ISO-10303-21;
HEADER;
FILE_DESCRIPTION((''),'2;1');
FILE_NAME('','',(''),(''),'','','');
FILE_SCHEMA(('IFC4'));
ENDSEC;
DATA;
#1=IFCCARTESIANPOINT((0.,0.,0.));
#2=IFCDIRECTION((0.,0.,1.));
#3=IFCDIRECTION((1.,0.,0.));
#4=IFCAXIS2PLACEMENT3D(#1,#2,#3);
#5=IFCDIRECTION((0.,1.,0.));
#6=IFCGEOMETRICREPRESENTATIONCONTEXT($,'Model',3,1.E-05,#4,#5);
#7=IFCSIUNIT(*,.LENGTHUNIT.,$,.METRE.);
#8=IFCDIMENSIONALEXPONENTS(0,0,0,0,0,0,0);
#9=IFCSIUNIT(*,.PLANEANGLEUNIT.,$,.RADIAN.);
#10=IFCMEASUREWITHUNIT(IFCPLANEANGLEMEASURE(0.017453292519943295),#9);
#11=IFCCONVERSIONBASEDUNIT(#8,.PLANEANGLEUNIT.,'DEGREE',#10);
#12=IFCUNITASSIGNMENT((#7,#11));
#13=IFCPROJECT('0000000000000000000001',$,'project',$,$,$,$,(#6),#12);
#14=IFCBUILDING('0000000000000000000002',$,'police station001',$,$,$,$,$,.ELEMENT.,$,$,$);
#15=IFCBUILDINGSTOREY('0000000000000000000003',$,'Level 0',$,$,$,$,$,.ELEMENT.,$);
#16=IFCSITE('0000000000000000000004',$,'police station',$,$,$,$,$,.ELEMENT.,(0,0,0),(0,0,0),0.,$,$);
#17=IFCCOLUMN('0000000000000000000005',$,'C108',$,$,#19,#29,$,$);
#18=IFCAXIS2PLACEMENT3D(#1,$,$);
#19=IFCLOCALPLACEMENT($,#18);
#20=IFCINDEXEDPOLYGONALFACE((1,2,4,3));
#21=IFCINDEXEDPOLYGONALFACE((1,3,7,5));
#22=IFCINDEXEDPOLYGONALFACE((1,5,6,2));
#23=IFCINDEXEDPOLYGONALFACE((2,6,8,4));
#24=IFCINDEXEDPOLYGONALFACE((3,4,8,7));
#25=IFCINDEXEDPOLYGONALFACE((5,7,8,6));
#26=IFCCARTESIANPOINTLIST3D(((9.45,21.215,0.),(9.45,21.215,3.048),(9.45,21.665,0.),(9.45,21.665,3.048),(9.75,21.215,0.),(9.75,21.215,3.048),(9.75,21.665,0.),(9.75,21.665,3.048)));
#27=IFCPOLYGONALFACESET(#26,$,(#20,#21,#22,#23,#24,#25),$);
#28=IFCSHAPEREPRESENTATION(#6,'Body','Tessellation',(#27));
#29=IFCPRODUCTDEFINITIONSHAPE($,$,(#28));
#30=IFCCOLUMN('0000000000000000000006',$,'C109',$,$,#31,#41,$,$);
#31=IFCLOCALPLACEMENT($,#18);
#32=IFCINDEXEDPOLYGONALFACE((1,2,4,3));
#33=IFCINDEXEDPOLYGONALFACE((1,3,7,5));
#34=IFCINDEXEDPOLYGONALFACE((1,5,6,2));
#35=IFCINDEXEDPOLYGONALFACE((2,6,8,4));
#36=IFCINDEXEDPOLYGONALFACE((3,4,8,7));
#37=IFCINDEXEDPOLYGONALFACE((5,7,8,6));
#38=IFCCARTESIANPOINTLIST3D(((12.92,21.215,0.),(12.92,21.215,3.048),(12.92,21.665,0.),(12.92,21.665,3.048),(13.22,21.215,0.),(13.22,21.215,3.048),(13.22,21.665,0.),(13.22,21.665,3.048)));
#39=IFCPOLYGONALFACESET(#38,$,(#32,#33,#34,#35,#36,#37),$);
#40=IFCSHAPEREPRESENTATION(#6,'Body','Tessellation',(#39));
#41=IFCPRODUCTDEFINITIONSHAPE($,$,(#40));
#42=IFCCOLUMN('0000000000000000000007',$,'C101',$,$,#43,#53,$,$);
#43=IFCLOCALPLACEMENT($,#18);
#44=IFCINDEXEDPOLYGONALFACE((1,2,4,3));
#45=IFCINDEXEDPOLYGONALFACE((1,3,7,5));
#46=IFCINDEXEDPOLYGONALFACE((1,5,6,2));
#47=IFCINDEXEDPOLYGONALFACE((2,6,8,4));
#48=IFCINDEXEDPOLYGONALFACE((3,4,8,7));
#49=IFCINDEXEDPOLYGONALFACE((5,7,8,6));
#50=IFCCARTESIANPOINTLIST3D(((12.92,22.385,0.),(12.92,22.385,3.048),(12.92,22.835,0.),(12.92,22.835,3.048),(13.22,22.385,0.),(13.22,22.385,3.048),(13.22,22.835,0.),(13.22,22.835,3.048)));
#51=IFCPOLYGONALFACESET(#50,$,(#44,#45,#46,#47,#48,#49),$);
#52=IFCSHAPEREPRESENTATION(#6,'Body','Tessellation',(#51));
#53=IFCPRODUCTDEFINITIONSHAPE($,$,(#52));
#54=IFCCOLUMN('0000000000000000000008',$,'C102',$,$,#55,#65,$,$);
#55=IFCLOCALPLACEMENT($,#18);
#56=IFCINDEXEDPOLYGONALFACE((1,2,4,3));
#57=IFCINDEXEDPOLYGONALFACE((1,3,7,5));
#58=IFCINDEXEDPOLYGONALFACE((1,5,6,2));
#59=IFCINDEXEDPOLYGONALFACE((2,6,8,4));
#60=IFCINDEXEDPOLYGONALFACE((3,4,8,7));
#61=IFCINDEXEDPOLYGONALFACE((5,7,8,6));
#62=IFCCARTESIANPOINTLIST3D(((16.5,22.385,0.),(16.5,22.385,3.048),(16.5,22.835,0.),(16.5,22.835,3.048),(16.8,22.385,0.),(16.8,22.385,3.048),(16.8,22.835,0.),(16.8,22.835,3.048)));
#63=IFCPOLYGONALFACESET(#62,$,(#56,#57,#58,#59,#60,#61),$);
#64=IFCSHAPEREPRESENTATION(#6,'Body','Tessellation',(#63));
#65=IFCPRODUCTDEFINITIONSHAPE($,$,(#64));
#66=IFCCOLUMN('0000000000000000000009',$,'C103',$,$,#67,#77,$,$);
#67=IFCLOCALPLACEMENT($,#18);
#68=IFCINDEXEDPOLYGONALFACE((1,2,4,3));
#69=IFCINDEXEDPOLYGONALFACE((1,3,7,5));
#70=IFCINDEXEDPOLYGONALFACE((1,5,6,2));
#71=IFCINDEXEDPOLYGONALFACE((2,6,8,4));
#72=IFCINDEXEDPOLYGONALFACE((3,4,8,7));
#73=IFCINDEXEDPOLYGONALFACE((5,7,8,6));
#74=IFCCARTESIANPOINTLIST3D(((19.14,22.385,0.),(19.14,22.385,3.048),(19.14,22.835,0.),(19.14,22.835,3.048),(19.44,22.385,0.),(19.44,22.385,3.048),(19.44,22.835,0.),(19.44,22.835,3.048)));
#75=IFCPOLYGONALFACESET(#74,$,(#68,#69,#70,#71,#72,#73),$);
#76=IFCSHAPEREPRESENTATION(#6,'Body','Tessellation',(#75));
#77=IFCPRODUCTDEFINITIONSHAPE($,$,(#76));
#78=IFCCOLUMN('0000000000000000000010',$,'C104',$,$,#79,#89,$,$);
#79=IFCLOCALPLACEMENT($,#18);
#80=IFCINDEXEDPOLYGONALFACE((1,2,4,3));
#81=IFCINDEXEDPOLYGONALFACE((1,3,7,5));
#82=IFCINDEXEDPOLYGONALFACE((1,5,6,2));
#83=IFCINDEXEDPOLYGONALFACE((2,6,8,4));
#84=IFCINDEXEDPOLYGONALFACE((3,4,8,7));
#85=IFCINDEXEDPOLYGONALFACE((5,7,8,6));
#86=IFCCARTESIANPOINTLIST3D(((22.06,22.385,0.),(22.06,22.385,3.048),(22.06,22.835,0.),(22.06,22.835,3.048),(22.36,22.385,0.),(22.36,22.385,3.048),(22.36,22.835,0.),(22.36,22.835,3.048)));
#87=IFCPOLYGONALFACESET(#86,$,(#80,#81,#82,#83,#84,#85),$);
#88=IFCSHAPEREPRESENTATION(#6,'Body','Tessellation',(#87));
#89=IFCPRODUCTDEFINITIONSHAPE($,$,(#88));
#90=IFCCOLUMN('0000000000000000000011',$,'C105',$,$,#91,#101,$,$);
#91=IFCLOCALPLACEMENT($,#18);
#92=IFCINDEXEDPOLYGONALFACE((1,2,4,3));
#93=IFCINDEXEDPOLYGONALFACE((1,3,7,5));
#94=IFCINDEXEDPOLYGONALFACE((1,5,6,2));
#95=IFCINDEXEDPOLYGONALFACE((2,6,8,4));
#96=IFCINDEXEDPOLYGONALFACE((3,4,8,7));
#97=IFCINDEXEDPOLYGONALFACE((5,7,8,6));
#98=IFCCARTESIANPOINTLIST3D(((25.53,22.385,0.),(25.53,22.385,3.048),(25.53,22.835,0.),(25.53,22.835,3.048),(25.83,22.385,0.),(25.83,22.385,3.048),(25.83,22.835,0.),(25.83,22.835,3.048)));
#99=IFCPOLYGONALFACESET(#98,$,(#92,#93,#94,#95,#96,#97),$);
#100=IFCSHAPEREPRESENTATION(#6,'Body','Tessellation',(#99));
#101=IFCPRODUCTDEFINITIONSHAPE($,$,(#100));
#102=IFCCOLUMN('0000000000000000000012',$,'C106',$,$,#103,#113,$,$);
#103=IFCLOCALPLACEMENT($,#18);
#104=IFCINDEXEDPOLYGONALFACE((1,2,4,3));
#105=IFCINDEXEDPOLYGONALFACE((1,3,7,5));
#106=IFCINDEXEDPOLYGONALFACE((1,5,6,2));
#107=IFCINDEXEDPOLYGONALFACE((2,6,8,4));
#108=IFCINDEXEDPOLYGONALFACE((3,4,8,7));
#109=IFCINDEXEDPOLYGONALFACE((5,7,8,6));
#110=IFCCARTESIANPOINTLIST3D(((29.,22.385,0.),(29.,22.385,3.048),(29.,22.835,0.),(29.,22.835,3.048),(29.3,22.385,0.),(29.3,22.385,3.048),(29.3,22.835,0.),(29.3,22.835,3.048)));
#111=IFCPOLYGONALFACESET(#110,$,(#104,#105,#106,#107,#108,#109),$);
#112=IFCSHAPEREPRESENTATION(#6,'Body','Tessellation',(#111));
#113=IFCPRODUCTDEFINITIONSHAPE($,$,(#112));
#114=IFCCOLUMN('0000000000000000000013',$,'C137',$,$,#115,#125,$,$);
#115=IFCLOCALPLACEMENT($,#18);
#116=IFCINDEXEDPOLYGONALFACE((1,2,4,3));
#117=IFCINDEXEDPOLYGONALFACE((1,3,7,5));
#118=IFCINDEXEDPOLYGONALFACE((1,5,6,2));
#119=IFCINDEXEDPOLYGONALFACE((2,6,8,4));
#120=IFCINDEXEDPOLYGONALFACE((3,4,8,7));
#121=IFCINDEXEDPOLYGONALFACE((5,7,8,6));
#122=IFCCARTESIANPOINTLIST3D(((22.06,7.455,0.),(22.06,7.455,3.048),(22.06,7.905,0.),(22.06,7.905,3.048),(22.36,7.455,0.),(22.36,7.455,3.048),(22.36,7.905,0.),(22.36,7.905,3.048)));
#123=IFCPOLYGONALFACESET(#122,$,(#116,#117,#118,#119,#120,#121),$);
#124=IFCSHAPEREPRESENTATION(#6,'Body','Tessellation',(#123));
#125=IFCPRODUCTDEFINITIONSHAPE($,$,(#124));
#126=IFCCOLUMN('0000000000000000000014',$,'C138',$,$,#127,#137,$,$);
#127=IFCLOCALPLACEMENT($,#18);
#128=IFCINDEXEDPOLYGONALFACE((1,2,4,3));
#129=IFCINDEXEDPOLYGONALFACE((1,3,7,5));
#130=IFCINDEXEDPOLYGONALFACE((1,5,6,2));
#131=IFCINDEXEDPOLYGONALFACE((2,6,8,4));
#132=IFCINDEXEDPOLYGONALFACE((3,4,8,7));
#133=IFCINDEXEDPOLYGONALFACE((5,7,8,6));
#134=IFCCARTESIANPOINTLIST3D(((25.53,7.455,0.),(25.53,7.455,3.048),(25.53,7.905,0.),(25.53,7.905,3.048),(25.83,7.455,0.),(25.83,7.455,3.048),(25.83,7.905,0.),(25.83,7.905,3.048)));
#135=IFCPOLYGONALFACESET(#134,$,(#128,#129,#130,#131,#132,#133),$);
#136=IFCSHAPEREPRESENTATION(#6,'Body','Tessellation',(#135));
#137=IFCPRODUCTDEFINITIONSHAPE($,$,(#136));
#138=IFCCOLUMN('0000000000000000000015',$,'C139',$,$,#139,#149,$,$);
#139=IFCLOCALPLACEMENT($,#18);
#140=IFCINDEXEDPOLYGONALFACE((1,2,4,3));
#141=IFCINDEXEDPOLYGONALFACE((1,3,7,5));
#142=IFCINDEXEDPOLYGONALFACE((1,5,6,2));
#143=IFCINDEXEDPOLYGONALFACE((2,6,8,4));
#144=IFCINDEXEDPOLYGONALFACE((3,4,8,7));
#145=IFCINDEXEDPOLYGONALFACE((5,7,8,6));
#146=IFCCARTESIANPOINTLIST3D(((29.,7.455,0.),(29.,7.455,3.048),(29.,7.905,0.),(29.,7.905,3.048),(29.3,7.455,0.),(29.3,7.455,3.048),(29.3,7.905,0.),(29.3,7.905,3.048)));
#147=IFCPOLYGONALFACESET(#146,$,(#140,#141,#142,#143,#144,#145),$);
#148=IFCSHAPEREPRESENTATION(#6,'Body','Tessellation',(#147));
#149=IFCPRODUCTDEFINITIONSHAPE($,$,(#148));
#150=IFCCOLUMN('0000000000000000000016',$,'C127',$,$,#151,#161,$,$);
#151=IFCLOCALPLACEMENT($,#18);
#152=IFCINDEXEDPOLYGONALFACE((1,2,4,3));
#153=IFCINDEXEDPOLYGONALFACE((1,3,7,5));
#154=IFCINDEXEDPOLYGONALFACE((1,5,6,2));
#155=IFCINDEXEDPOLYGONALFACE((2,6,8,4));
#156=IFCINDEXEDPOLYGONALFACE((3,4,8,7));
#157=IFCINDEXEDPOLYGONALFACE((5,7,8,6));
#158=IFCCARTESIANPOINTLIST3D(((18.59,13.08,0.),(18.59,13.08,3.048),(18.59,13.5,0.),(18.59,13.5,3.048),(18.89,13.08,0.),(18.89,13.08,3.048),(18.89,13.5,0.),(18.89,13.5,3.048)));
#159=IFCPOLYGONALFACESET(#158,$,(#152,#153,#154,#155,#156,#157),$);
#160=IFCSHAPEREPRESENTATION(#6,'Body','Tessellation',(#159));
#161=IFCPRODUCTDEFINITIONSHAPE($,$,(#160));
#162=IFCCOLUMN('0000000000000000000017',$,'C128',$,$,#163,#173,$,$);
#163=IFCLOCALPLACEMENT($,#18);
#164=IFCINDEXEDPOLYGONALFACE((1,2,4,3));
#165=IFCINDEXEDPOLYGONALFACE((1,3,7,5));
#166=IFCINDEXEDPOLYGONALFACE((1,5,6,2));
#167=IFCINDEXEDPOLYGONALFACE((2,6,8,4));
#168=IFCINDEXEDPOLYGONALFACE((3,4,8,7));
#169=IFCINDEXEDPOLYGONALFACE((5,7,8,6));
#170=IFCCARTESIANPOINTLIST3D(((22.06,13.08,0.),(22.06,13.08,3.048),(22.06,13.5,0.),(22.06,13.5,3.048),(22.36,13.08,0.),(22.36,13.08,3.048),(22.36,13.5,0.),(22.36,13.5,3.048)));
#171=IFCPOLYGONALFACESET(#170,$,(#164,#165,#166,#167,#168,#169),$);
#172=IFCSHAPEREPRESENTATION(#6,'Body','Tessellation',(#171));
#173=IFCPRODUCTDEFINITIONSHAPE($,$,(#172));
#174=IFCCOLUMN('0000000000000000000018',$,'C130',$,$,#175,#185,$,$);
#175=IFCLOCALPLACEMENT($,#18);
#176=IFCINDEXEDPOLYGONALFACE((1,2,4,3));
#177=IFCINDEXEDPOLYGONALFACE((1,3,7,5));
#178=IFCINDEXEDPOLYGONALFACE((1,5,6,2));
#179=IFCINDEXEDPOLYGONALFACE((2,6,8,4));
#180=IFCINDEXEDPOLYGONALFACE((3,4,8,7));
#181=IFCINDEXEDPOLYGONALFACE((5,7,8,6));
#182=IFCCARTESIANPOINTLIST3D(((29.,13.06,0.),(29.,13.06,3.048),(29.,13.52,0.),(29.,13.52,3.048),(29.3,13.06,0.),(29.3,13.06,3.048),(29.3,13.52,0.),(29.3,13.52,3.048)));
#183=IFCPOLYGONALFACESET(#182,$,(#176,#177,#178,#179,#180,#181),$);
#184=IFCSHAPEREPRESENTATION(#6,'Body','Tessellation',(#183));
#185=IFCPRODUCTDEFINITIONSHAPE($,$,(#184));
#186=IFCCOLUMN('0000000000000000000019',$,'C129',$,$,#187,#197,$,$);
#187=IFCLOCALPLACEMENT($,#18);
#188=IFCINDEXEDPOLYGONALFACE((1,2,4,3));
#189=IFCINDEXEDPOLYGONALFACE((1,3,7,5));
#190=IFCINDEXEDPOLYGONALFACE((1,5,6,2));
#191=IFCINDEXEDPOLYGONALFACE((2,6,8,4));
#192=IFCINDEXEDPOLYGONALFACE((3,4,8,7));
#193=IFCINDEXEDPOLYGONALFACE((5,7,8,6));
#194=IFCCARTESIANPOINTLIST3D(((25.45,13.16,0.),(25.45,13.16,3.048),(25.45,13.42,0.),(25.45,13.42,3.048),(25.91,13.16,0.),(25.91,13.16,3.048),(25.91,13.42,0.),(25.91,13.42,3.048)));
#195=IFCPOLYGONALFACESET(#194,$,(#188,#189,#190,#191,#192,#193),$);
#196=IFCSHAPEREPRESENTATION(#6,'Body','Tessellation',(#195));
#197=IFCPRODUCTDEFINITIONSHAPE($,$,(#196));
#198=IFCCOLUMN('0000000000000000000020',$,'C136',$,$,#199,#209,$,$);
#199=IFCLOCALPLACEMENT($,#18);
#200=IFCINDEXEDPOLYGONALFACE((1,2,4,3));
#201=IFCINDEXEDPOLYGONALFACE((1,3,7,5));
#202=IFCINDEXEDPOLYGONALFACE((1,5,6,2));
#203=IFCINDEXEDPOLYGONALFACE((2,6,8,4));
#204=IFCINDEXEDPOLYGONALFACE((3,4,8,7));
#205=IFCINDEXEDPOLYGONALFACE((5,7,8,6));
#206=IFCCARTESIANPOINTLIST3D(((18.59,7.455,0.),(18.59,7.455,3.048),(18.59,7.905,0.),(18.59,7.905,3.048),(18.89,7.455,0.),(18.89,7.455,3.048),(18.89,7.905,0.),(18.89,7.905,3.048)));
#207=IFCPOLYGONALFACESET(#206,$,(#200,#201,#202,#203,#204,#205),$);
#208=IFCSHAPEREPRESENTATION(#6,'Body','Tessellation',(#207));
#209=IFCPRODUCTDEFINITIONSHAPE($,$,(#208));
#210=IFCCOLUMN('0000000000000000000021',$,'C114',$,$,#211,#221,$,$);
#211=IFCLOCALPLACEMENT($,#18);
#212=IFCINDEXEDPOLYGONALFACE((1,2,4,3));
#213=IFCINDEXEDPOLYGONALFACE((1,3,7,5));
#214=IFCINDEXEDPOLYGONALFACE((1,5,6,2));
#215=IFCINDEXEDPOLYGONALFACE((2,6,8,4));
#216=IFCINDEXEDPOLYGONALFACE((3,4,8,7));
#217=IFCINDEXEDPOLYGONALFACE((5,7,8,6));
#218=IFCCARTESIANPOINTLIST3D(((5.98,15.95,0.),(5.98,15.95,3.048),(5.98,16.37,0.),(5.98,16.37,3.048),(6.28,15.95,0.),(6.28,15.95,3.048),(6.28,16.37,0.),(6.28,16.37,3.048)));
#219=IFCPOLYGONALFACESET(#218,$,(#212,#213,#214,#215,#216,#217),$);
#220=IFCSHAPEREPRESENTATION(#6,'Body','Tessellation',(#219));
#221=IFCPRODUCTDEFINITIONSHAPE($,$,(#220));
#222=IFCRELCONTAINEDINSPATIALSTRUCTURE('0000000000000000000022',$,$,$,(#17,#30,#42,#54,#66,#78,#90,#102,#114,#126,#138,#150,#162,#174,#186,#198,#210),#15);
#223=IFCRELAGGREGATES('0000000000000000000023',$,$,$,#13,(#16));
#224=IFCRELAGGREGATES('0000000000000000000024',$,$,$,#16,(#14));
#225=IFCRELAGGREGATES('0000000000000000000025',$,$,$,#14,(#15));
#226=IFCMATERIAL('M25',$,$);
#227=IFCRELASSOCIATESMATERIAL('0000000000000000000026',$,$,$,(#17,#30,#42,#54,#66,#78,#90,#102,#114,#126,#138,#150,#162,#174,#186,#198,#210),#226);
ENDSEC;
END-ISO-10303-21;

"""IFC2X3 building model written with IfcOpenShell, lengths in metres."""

from ifc_helpers import new_model, entity, si_unit, converted_unit, direction, frame, frame_2d, origin_with_axes, place, context, project, spatial, rectangle, extrude, material, element, save


model = new_model("IFC2X3")

# Units and contexts
model_context = context("Model", 3, precision=1e-05, world=origin_with_axes(), true_north=direction((0.0, 1.0, 0.0)))
ifc_project = project(units=[si_unit("LENGTHUNIT", "METRE"), converted_unit("PLANEANGLEUNIT", "DEGREE", entity("IfcPlaneAngleMeasure", 0.017453292519943295), si_unit("PLANEANGLEUNIT", "RADIAN"), dimensions=[0, 0, 0, 0, 0, 0, 0])], contexts=[model_context])

# Site, building, storey
site = spatial("IfcSite", under=ifc_project, Name="police station", CompositionType="ELEMENT", RefLatitude=(0, 0, 0), RefLongitude=(0, 0, 0), RefElevation=0.0)
building = spatial("IfcBuilding", under=site, Name="police station001", CompositionType="ELEMENT")
storey = spatial("IfcBuildingStorey", under=building, Name="Level 0", CompositionType="ELEMENT")

# Columns
ifc_material = material(Name="M25")
placement = place(None, origin_with_axes())
element("IfcColumn", 1, at=placement, inside=storey, material=ifc_material, Name="C108", context=model_context, shape_type="SweptSolid", body=[
    extrude(rectangle(XDim=0.3, YDim=0.45, at=frame_2d((0.0, 0.0), x_axis=(1.0, 0.0, 0.0))), frame((9.6, 21.44, 0.0), z_axis=(0.0, 0.0, 1.0), x_axis=(1.0, 0.0, 0.0)), (0.0, 0.0, 1.0), 3.048),
])
element("IfcColumn", 2, at=placement, inside=storey, material=ifc_material, Name="C109", context=model_context, shape_type="SweptSolid", body=[
    extrude(rectangle(XDim=0.3, YDim=0.45, at=frame_2d((0.0, 0.0), x_axis=(1.0, 0.0, 0.0))), frame((13.07, 21.44, 0.0), z_axis=(0.0, 0.0, 1.0), x_axis=(1.0, 0.0, 0.0)), (0.0, 0.0, 1.0), 3.048),
])
element("IfcColumn", 3, at=placement, inside=storey, material=ifc_material, Name="C101", context=model_context, shape_type="SweptSolid", body=[
    extrude(rectangle(XDim=0.3, YDim=0.45, at=frame_2d((0.0, 0.0), x_axis=(1.0, 0.0, 0.0))), frame((13.07, 22.61, 0.0), z_axis=(0.0, 0.0, 1.0), x_axis=(1.0, 0.0, 0.0)), (0.0, 0.0, 1.0), 3.048),
])
element("IfcColumn", 4, at=placement, inside=storey, material=ifc_material, Name="C102", context=model_context, shape_type="SweptSolid", body=[
    extrude(rectangle(XDim=0.3, YDim=0.45, at=frame_2d((0.0, 0.0), x_axis=(1.0, 0.0, 0.0))), frame((16.65, 22.61, 0.0), z_axis=(0.0, 0.0, 1.0), x_axis=(1.0, 0.0, 0.0)), (0.0, 0.0, 1.0), 3.048),
])
element("IfcColumn", 5, at=placement, inside=storey, material=ifc_material, Name="C103", context=model_context, shape_type="SweptSolid", body=[
    extrude(rectangle(XDim=0.3, YDim=0.45, at=frame_2d((0.0, 0.0), x_axis=(1.0, 0.0, 0.0))), frame((19.29, 22.61, 0.0), z_axis=(0.0, 0.0, 1.0), x_axis=(1.0, 0.0, 0.0)), (0.0, 0.0, 1.0), 3.048),
])
element("IfcColumn", 6, at=placement, inside=storey, material=ifc_material, Name="C104", context=model_context, shape_type="SweptSolid", body=[
    extrude(rectangle(XDim=0.3, YDim=0.45, at=frame_2d((0.0, 0.0), x_axis=(1.0, 0.0, 0.0))), frame((22.21, 22.61, 0.0), z_axis=(0.0, 0.0, 1.0), x_axis=(1.0, 0.0, 0.0)), (0.0, 0.0, 1.0), 3.048),
])
element("IfcColumn", 7, at=placement, inside=storey, material=ifc_material, Name="C105", context=model_context, shape_type="SweptSolid", body=[
    extrude(rectangle(XDim=0.3, YDim=0.45, at=frame_2d((0.0, 0.0), x_axis=(1.0, 0.0, 0.0))), frame((25.68, 22.61, 0.0), z_axis=(0.0, 0.0, 1.0), x_axis=(1.0, 0.0, 0.0)), (0.0, 0.0, 1.0), 3.048),
])
element("IfcColumn", 8, at=placement, inside=storey, material=ifc_material, Name="C106", context=model_context, shape_type="SweptSolid", body=[
    extrude(rectangle(XDim=0.3, YDim=0.45, at=frame_2d((0.0, 0.0), x_axis=(1.0, 0.0, 0.0))), frame((29.15, 22.61, 0.0), z_axis=(0.0, 0.0, 1.0), x_axis=(1.0, 0.0, 0.0)), (0.0, 0.0, 1.0), 3.048),
])
element("IfcColumn", 9, at=placement, inside=storey, material=ifc_material, Name="C137", context=model_context, shape_type="SweptSolid", body=[
    extrude(rectangle(XDim=0.3, YDim=0.45, at=frame_2d((0.0, 0.0), x_axis=(1.0, 0.0, 0.0))), frame((22.21, 7.68, 0.0), z_axis=(0.0, 0.0, 1.0), x_axis=(1.0, 0.0, 0.0)), (0.0, 0.0, 1.0), 3.048),
])
element("IfcColumn", 10, at=placement, inside=storey, material=ifc_material, Name="C138", context=model_context, shape_type="SweptSolid", body=[
    extrude(rectangle(XDim=0.3, YDim=0.45, at=frame_2d((0.0, 0.0), x_axis=(1.0, 0.0, 0.0))), frame((25.68, 7.68, 0.0), z_axis=(0.0, 0.0, 1.0), x_axis=(1.0, 0.0, 0.0)), (0.0, 0.0, 1.0), 3.048),
])
element("IfcColumn", 11, at=placement, inside=storey, material=ifc_material, Name="C139", context=model_context, shape_type="SweptSolid", body=[
    extrude(rectangle(XDim=0.3, YDim=0.45, at=frame_2d((0.0, 0.0), x_axis=(1.0, 0.0, 0.0))), frame((29.15, 7.68, 0.0), z_axis=(0.0, 0.0, 1.0), x_axis=(1.0, 0.0, 0.0)), (0.0, 0.0, 1.0), 3.048),
])
element("IfcColumn", 12, at=placement, inside=storey, material=ifc_material, Name="C127", context=model_context, shape_type="SweptSolid", body=[
    extrude(rectangle(XDim=0.3, YDim=0.42, at=frame_2d((0.0, 0.0), x_axis=(1.0, 0.0, 0.0))), frame((18.74, 13.29, 0.0), z_axis=(0.0, 0.0, 1.0), x_axis=(1.0, 0.0, 0.0)), (0.0, 0.0, 1.0), 3.048),
])
element("IfcColumn", 13, at=placement, inside=storey, material=ifc_material, Name="C128", context=model_context, shape_type="SweptSolid", body=[
    extrude(rectangle(XDim=0.3, YDim=0.42, at=frame_2d((0.0, 0.0), x_axis=(1.0, 0.0, 0.0))), frame((22.21, 13.29, 0.0), z_axis=(0.0, 0.0, 1.0), x_axis=(1.0, 0.0, 0.0)), (0.0, 0.0, 1.0), 3.048),
])
element("IfcColumn", 14, at=placement, inside=storey, material=ifc_material, Name="C130", context=model_context, shape_type="SweptSolid", body=[
    extrude(rectangle(XDim=0.3, YDim=0.46, at=frame_2d((0.0, 0.0), x_axis=(1.0, 0.0, 0.0))), frame((29.15, 13.29, 0.0), z_axis=(0.0, 0.0, 1.0), x_axis=(1.0, 0.0, 0.0)), (0.0, 0.0, 1.0), 3.048),
])
element("IfcColumn", 15, at=placement, inside=storey, material=ifc_material, Name="C129", context=model_context, shape_type="SweptSolid", body=[
    extrude(rectangle(XDim=0.46, YDim=0.26, at=frame_2d((0.0, 0.0), x_axis=(1.0, 0.0, 0.0))), frame((25.68, 13.29, 0.0), z_axis=(0.0, 0.0, 1.0), x_axis=(1.0, 0.0, 0.0)), (0.0, 0.0, 1.0), 3.048),
])
element("IfcColumn", 16, at=placement, inside=storey, material=ifc_material, Name="C136", context=model_context, shape_type="SweptSolid", body=[
    extrude(rectangle(XDim=0.3, YDim=0.45, at=frame_2d((0.0, 0.0), x_axis=(1.0, 0.0, 0.0))), frame((18.74, 7.68, 0.0), z_axis=(0.0, 0.0, 1.0), x_axis=(1.0, 0.0, 0.0)), (0.0, 0.0, 1.0), 3.048),
])
element("IfcColumn", 17, at=placement, inside=storey, material=ifc_material, Name="C114", context=model_context, shape_type="SweptSolid", body=[
    extrude(rectangle(XDim=0.3, YDim=0.42, at=frame_2d((0.0, 0.0), x_axis=(1.0, 0.0, 0.0))), frame((6.13, 16.16, 0.0), z_axis=(0.0, 0.0, 1.0), x_axis=(1.0, 0.0, 0.0)), (0.0, 0.0, 1.0), 3.048),
])

save(model, "model.ifc")
